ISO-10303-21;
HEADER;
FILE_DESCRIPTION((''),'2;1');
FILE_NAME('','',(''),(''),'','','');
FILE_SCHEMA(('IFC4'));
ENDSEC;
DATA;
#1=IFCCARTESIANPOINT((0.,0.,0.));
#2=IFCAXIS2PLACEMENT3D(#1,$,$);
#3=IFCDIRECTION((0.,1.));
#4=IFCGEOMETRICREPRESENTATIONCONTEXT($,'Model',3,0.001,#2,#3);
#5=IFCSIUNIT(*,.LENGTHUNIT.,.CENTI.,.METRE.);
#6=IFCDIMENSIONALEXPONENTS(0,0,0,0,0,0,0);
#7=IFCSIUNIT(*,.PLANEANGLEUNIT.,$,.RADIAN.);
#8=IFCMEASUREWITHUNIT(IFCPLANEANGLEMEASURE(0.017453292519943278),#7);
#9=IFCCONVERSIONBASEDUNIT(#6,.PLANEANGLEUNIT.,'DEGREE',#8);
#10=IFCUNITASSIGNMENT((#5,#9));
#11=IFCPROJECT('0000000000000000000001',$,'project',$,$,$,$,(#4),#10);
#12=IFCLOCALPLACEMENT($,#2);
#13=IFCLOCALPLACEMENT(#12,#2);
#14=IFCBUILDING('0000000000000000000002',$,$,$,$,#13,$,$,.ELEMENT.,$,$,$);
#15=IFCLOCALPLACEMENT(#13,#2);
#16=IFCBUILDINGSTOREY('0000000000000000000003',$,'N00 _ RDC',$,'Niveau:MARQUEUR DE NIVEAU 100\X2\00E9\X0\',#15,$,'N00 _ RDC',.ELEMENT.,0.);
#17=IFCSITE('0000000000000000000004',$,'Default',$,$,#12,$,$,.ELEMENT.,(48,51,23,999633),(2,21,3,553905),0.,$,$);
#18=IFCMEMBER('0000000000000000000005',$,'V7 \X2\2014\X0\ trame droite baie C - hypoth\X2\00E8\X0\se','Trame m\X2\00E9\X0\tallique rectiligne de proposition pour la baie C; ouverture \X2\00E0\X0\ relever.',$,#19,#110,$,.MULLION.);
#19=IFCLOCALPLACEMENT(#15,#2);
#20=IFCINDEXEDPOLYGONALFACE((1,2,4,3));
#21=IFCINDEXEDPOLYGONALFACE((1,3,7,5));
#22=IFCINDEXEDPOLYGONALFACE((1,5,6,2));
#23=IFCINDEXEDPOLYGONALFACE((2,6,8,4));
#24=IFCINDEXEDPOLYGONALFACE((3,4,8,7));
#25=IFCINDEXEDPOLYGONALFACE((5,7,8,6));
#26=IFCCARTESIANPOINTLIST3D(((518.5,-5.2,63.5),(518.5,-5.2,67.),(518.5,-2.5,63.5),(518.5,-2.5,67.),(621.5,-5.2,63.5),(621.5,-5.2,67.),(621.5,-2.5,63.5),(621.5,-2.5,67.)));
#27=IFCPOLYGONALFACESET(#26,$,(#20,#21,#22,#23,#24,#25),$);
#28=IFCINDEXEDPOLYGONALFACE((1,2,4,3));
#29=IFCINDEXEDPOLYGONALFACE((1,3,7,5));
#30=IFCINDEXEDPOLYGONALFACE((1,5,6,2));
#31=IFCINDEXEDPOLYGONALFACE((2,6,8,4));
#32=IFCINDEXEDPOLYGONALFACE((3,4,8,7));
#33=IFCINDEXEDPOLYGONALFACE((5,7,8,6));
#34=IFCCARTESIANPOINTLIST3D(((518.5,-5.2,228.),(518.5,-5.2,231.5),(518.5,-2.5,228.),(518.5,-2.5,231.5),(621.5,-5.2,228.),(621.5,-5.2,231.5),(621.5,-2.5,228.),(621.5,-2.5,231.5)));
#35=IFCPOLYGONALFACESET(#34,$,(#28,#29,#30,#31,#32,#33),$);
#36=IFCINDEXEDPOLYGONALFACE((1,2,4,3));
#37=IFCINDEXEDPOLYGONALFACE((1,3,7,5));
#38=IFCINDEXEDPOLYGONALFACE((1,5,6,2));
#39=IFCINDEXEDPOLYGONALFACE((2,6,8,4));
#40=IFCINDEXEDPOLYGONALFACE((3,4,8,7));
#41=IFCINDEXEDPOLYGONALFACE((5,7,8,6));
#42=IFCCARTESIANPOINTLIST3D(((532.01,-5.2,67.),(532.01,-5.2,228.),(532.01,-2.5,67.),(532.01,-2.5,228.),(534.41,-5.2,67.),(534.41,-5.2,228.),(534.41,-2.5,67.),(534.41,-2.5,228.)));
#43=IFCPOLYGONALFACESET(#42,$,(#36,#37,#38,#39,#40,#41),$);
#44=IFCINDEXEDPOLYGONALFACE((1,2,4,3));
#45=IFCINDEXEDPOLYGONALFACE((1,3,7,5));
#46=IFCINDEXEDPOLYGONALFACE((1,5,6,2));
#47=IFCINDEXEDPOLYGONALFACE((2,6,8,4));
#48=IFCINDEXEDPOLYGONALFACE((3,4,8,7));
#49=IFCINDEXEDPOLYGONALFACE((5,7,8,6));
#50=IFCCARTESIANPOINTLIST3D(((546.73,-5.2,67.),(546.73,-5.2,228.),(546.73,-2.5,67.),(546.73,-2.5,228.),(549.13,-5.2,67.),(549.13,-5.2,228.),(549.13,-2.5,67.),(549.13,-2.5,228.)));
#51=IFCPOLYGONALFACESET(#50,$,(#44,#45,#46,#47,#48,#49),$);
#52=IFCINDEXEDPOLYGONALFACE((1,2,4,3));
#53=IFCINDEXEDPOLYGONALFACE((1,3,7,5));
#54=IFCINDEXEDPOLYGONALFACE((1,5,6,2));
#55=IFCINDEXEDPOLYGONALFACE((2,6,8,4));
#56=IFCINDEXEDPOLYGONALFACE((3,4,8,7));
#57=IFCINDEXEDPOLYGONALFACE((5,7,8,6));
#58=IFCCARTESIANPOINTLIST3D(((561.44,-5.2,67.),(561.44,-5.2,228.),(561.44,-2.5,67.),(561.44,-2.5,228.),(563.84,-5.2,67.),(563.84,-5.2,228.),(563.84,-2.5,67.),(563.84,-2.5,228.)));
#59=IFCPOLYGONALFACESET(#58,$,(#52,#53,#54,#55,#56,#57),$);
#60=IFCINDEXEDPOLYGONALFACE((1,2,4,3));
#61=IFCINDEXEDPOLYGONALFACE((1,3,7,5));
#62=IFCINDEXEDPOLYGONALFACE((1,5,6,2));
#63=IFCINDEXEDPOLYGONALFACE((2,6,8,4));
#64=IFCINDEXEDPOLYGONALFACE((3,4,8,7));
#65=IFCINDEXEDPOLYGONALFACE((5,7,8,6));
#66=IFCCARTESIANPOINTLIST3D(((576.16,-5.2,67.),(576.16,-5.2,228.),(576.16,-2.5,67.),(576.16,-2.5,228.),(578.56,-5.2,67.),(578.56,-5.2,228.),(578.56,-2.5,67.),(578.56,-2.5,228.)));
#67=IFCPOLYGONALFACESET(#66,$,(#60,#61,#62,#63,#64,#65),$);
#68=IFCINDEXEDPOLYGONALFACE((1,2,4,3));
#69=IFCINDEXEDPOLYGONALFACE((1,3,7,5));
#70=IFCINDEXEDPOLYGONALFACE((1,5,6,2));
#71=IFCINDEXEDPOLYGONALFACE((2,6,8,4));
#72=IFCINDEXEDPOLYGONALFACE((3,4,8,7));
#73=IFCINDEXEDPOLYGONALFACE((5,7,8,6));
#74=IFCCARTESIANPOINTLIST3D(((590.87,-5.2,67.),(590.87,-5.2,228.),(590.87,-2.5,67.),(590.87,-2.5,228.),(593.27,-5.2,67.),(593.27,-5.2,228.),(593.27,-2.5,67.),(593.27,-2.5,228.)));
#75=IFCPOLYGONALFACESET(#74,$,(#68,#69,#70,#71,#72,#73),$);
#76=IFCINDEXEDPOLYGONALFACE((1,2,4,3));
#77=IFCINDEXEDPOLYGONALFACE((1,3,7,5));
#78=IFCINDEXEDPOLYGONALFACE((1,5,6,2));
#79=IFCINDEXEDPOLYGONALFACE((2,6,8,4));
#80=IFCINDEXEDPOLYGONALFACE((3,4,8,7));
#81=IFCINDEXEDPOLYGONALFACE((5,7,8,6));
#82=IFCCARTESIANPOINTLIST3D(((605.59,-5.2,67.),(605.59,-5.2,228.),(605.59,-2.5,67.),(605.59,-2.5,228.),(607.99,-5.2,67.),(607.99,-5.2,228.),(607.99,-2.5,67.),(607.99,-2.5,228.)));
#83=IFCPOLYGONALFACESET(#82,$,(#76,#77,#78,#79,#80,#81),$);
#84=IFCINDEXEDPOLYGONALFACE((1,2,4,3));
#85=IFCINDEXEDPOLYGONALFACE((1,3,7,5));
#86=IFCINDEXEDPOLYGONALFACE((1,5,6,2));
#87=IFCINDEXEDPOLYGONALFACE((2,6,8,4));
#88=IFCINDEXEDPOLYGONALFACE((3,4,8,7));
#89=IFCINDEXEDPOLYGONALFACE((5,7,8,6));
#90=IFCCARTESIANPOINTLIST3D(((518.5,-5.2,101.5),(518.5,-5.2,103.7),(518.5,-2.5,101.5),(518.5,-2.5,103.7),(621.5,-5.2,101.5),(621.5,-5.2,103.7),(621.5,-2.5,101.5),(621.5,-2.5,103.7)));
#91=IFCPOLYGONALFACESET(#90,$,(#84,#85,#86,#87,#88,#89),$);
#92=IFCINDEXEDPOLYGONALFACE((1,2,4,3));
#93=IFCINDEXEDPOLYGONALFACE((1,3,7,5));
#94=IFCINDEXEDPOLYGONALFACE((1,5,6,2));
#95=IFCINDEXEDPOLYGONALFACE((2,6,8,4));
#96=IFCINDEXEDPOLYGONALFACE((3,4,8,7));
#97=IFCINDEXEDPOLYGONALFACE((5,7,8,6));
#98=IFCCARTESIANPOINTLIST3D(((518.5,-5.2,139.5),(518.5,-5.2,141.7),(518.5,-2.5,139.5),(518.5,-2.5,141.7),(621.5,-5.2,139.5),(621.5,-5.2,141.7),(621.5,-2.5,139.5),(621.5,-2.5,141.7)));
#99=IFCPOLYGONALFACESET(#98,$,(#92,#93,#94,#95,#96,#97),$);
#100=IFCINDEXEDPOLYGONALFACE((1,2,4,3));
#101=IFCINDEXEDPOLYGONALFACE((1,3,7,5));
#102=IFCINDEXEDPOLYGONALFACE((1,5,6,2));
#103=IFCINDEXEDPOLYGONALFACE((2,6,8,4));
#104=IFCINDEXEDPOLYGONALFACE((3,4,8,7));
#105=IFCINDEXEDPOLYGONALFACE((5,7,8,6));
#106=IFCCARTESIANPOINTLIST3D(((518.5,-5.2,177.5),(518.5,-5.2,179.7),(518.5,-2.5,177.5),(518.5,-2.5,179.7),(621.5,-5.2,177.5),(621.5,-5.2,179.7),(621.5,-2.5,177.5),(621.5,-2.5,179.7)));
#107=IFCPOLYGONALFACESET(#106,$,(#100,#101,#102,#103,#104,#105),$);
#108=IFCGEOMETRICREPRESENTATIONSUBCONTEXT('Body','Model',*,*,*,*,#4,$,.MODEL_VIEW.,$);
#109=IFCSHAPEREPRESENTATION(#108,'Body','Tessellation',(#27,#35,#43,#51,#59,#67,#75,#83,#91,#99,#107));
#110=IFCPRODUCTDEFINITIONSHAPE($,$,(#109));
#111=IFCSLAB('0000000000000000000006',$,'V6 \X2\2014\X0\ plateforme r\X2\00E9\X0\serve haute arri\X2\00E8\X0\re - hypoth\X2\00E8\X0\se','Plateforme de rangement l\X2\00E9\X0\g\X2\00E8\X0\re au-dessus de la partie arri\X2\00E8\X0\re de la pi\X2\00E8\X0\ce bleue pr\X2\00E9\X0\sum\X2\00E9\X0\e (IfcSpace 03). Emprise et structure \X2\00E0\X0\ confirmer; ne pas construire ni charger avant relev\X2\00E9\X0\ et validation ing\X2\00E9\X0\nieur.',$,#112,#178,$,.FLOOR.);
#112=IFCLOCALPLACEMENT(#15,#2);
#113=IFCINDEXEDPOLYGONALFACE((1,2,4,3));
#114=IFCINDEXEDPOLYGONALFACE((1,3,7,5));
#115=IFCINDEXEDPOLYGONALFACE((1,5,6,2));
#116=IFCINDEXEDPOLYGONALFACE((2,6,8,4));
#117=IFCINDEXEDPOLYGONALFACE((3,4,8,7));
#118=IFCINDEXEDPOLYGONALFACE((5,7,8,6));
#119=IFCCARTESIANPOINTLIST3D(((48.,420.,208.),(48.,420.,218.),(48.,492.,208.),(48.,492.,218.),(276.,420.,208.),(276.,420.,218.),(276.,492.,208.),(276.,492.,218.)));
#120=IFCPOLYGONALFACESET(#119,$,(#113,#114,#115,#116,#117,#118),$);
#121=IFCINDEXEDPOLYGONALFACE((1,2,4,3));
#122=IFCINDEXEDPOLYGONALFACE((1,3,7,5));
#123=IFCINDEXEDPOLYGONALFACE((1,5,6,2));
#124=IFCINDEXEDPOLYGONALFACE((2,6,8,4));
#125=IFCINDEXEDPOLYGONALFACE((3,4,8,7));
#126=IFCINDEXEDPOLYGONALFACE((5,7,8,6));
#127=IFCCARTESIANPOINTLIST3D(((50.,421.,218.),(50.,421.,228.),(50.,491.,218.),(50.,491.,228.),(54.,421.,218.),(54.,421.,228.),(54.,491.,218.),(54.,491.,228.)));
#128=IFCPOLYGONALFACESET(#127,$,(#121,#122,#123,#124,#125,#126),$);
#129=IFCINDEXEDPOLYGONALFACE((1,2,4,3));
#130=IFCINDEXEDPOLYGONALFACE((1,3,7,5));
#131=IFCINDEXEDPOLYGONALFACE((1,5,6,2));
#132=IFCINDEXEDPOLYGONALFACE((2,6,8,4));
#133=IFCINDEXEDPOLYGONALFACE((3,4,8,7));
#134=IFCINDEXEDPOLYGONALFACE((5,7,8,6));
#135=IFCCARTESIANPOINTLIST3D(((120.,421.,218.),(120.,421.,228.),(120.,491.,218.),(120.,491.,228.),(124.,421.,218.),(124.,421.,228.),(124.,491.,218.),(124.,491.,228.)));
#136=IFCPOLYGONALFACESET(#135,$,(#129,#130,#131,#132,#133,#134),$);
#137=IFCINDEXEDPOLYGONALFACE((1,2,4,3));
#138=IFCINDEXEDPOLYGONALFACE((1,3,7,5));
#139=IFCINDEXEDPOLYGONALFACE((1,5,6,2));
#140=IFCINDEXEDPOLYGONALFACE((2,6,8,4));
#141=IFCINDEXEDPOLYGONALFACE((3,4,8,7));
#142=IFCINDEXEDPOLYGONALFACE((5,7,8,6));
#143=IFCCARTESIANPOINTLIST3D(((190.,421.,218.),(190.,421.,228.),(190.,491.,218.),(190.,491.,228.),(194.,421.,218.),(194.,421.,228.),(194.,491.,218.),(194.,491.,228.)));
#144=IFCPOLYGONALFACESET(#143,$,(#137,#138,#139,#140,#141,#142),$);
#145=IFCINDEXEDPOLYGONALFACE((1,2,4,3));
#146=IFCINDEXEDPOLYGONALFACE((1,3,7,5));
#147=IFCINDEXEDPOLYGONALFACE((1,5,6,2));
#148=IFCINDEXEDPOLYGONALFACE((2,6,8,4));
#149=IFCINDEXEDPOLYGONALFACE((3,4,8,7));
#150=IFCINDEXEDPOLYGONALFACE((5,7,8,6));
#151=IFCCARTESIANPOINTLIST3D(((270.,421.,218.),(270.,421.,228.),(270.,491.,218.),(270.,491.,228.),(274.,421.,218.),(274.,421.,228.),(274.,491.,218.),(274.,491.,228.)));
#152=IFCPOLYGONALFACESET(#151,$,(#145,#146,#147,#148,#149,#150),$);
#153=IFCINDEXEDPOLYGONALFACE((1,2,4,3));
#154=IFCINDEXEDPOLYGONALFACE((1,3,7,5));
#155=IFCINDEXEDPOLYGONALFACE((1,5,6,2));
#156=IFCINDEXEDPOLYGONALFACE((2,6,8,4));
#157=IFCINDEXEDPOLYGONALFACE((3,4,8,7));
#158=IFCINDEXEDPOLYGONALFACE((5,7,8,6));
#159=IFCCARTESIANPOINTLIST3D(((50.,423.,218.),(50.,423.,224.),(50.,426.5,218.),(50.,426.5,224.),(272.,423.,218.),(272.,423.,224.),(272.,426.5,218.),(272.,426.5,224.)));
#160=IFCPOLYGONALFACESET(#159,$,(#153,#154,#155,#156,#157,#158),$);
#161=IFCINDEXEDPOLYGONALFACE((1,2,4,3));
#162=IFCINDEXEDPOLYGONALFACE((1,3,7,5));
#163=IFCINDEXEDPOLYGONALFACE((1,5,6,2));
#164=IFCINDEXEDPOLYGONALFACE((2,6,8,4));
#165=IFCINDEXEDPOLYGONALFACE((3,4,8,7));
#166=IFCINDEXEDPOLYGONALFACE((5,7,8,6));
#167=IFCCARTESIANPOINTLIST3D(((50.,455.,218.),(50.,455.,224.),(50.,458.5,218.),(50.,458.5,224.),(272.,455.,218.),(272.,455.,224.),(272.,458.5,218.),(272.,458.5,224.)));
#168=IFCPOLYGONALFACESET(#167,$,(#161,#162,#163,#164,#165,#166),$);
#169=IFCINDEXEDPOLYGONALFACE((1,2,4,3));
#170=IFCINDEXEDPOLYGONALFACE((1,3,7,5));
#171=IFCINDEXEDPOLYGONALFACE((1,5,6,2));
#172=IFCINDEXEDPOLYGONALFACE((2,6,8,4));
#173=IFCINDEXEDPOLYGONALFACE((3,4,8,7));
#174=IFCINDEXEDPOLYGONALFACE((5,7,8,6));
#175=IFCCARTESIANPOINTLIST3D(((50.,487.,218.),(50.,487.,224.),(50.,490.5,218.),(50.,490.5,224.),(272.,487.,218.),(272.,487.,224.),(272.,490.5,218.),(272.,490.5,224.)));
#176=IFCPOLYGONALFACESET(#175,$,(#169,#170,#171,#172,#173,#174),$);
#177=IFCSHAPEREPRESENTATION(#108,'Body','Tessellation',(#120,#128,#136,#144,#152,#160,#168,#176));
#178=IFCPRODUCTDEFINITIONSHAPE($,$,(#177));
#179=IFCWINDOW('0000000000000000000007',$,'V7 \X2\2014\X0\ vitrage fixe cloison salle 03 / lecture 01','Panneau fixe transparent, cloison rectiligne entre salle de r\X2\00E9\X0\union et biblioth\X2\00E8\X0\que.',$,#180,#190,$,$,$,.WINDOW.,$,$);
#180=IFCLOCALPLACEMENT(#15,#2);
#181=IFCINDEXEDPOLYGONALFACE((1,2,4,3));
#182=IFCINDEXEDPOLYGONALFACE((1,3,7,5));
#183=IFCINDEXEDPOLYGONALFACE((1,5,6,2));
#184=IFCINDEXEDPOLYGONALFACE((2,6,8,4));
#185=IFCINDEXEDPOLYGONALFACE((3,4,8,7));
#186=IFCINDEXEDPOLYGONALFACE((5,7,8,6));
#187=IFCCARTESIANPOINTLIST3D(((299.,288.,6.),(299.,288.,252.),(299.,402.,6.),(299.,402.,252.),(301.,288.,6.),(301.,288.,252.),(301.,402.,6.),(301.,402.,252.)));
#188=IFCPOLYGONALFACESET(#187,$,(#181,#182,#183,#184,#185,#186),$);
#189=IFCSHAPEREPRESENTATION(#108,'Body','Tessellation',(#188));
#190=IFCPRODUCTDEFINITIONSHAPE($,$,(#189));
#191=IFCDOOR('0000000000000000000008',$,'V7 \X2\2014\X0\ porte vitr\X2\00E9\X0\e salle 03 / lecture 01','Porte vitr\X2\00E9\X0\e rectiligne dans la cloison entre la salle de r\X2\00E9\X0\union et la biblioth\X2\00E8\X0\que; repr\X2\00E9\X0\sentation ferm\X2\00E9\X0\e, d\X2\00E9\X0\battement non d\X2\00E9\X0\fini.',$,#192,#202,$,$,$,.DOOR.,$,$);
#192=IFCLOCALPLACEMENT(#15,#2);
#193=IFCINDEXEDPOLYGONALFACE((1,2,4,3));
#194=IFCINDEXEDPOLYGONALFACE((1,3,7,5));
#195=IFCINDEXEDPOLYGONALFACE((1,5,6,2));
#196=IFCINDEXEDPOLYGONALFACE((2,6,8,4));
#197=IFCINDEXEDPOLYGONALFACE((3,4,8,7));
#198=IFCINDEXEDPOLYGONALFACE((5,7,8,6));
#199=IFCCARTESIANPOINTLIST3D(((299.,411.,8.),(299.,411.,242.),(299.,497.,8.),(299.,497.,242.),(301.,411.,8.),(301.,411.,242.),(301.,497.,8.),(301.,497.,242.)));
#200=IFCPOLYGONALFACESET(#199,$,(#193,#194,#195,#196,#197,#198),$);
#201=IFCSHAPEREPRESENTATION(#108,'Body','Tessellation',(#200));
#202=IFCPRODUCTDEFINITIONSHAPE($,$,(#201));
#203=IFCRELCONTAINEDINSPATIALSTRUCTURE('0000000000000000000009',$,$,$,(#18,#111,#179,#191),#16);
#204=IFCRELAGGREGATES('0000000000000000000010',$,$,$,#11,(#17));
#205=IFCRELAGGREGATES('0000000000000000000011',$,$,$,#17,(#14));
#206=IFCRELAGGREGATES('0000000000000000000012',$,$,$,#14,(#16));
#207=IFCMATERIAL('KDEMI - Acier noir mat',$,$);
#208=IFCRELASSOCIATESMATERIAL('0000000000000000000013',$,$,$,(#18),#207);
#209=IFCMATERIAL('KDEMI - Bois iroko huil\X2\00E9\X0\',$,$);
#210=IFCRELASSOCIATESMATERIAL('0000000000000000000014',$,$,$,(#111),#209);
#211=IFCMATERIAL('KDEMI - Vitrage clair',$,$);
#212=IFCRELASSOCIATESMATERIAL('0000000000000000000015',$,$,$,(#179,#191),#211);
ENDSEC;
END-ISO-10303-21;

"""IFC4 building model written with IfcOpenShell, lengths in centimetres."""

from ifc_helpers import new_model, entity, si_unit, converted_unit, direction, frame, frame_2d, origin, origin_with_axes, place, context, subcontext, project, spatial, rectangle, extrude, material, element, save


model = new_model("IFC4")

# Units and contexts
model_context = context("Model", 3, precision=0.001, world=origin(), true_north=direction((0.0, 1.0)))
body_context = subcontext(model_context, "Body", "Model", "MODEL_VIEW")
ifc_project = project(units=[si_unit("LENGTHUNIT", "METRE", prefix="CENTI"), converted_unit("PLANEANGLEUNIT", "DEGREE", entity("IfcPlaneAngleMeasure", 0.017453292519943278), si_unit("PLANEANGLEUNIT", "RADIAN"), dimensions=[0, 0, 0, 0, 0, 0, 0])], contexts=[model_context])

# Site, building, storey
site_placement = place(None, origin())
site = spatial("IfcSite", under=ifc_project, at=site_placement, Name="Default", CompositionType="ELEMENT", RefLatitude=(48, 51, 23, 999633), RefLongitude=(2, 21, 3, 553905), RefElevation=0.0)
building_placement = place(site_placement, origin())
building = spatial("IfcBuilding", under=site, at=building_placement, CompositionType="ELEMENT")
storey_placement = place(building_placement, origin())
storey = spatial("IfcBuildingStorey", under=building, at=storey_placement, Name="N00 _ RDC", ObjectType="Niveau:MARQUEUR DE NIVEAU 100é", LongName="N00 _ RDC", CompositionType="ELEMENT", Elevation=0.0)

# Member
ifc_material_1 = material(Name="KDEMI - Acier noir mat")
member_1_placement = place(storey_placement, origin_with_axes())
element("IfcMember", 1, at=member_1_placement, inside=storey, material=ifc_material_1, Name="V7 — trame droite baie C - hypothèse", Description="Trame métallique rectiligne de proposition pour la baie C; ouverture à relever.", PredefinedType="MULLION", context=body_context, shape_type="SweptSolid", body=[
    extrude(rectangle(XDim=103.0, YDim=2.7, at=frame_2d((570.0, -3.85))), frame((0.0, 0.0, 63.5)), (0.0, 0.0, 1.0), 3.5),
    extrude(rectangle(XDim=103.0, YDim=2.7, at=frame_2d((570.0, -3.85))), frame((0.0, 0.0, 228.0)), (0.0, 0.0, 1.0), 3.5),
    extrude(rectangle(XDim=2.4, YDim=2.7, at=frame_2d((533.21, -3.85))), frame((0.0, 0.0, 67.0)), (0.0, 0.0, 1.0), 161.0),
    extrude(rectangle(XDim=2.4, YDim=2.7, at=frame_2d((547.93, -3.85))), frame((0.0, 0.0, 67.0)), (0.0, 0.0, 1.0), 161.0),
    extrude(rectangle(XDim=2.4, YDim=2.7, at=frame_2d((562.64, -3.85))), frame((0.0, 0.0, 67.0)), (0.0, 0.0, 1.0), 161.0),
    extrude(rectangle(XDim=2.4, YDim=2.7, at=frame_2d((577.36, -3.85))), frame((0.0, 0.0, 67.0)), (0.0, 0.0, 1.0), 161.0),
    extrude(rectangle(XDim=2.4, YDim=2.7, at=frame_2d((592.07, -3.85))), frame((0.0, 0.0, 67.0)), (0.0, 0.0, 1.0), 161.0),
    extrude(rectangle(XDim=2.4, YDim=2.7, at=frame_2d((606.79, -3.85))), frame((0.0, 0.0, 67.0)), (0.0, 0.0, 1.0), 161.0),
    extrude(rectangle(XDim=103.0, YDim=2.7, at=frame_2d((570.0, -3.85))), frame((0.0, 0.0, 101.5)), (0.0, 0.0, 1.0), 2.2),
    extrude(rectangle(XDim=103.0, YDim=2.7, at=frame_2d((570.0, -3.85))), frame((0.0, 0.0, 139.5)), (0.0, 0.0, 1.0), 2.2),
    extrude(rectangle(XDim=103.0, YDim=2.7, at=frame_2d((570.0, -3.85))), frame((0.0, 0.0, 177.5)), (0.0, 0.0, 1.0), 2.2),
])

# Slab
ifc_material_2 = material(Name="KDEMI - Bois iroko huilé")
slab_placement = place(storey_placement, origin_with_axes())
element("IfcSlab", 2, at=slab_placement, inside=storey, material=ifc_material_2, Name="V6 — plateforme réserve haute arrière - hypothèse", Description="Plateforme de rangement légère au-dessus de la partie arrière de la pièce bleue présumée (IfcSpace 03). Emprise et structure à confirmer; ne pas construire ni charger avant relevé et validation ingénieur.", PredefinedType="FLOOR", context=body_context, shape_type="SweptSolid", body=[
    extrude(rectangle(XDim=228.0, YDim=72.0, at=frame_2d((162.0, 456.0))), frame((0.0, 0.0, 208.0)), (0.0, 0.0, 1.0), 10.0),
    extrude(rectangle(XDim=4.0, YDim=70.0, at=frame_2d((52.0, 456.0))), frame((0.0, 0.0, 218.0)), (0.0, 0.0, 1.0), 10.0),
    extrude(rectangle(XDim=4.0, YDim=70.0, at=frame_2d((122.0, 456.0))), frame((0.0, 0.0, 218.0)), (0.0, 0.0, 1.0), 10.0),
    extrude(rectangle(XDim=4.0, YDim=70.0, at=frame_2d((192.0, 456.0))), frame((0.0, 0.0, 218.0)), (0.0, 0.0, 1.0), 10.0),
    extrude(rectangle(XDim=4.0, YDim=70.0, at=frame_2d((272.0, 456.0))), frame((0.0, 0.0, 218.0)), (0.0, 0.0, 1.0), 10.0),
    extrude(rectangle(XDim=222.0, YDim=3.5, at=frame_2d((161.0, 424.75))), frame((0.0, 0.0, 218.0)), (0.0, 0.0, 1.0), 6.0),
    extrude(rectangle(XDim=222.0, YDim=3.5, at=frame_2d((161.0, 456.75))), frame((0.0, 0.0, 218.0)), (0.0, 0.0, 1.0), 6.0),
    extrude(rectangle(XDim=222.0, YDim=3.5, at=frame_2d((161.0, 488.75))), frame((0.0, 0.0, 218.0)), (0.0, 0.0, 1.0), 6.0),
])

# Window
ifc_material_3 = material(Name="KDEMI - Vitrage clair")
window_1_placement = place(storey_placement, origin_with_axes())
element("IfcWindow", 3, at=window_1_placement, inside=storey, material=ifc_material_3, Name="V7 — vitrage fixe cloison salle 03 / lecture 01", Description="Panneau fixe transparent, cloison rectiligne entre salle de réunion et bibliothèque.", PredefinedType="WINDOW", context=body_context, shape_type="SweptSolid", body=[
    extrude(rectangle(XDim=2.0, YDim=114.0, at=frame_2d((300.0, 345.0))), frame((0.0, 0.0, 6.0)), (0.0, 0.0, 1.0), 246.0),
])

# Door
door_1_placement = place(storey_placement, origin_with_axes())
element("IfcDoor", 4, at=door_1_placement, inside=storey, material=ifc_material_3, Name="V7 — porte vitrée salle 03 / lecture 01", Description="Porte vitrée rectiligne dans la cloison entre la salle de réunion et la bibliothèque; représentation fermée, débattement non défini.", PredefinedType="DOOR", context=body_context, shape_type="SweptSolid", body=[
    extrude(rectangle(XDim=2.0, YDim=86.0, at=frame_2d((300.0, 454.0))), frame((0.0, 0.0, 8.0)), (0.0, 0.0, 1.0), 234.0),
])

save(model, "model.ifc")
